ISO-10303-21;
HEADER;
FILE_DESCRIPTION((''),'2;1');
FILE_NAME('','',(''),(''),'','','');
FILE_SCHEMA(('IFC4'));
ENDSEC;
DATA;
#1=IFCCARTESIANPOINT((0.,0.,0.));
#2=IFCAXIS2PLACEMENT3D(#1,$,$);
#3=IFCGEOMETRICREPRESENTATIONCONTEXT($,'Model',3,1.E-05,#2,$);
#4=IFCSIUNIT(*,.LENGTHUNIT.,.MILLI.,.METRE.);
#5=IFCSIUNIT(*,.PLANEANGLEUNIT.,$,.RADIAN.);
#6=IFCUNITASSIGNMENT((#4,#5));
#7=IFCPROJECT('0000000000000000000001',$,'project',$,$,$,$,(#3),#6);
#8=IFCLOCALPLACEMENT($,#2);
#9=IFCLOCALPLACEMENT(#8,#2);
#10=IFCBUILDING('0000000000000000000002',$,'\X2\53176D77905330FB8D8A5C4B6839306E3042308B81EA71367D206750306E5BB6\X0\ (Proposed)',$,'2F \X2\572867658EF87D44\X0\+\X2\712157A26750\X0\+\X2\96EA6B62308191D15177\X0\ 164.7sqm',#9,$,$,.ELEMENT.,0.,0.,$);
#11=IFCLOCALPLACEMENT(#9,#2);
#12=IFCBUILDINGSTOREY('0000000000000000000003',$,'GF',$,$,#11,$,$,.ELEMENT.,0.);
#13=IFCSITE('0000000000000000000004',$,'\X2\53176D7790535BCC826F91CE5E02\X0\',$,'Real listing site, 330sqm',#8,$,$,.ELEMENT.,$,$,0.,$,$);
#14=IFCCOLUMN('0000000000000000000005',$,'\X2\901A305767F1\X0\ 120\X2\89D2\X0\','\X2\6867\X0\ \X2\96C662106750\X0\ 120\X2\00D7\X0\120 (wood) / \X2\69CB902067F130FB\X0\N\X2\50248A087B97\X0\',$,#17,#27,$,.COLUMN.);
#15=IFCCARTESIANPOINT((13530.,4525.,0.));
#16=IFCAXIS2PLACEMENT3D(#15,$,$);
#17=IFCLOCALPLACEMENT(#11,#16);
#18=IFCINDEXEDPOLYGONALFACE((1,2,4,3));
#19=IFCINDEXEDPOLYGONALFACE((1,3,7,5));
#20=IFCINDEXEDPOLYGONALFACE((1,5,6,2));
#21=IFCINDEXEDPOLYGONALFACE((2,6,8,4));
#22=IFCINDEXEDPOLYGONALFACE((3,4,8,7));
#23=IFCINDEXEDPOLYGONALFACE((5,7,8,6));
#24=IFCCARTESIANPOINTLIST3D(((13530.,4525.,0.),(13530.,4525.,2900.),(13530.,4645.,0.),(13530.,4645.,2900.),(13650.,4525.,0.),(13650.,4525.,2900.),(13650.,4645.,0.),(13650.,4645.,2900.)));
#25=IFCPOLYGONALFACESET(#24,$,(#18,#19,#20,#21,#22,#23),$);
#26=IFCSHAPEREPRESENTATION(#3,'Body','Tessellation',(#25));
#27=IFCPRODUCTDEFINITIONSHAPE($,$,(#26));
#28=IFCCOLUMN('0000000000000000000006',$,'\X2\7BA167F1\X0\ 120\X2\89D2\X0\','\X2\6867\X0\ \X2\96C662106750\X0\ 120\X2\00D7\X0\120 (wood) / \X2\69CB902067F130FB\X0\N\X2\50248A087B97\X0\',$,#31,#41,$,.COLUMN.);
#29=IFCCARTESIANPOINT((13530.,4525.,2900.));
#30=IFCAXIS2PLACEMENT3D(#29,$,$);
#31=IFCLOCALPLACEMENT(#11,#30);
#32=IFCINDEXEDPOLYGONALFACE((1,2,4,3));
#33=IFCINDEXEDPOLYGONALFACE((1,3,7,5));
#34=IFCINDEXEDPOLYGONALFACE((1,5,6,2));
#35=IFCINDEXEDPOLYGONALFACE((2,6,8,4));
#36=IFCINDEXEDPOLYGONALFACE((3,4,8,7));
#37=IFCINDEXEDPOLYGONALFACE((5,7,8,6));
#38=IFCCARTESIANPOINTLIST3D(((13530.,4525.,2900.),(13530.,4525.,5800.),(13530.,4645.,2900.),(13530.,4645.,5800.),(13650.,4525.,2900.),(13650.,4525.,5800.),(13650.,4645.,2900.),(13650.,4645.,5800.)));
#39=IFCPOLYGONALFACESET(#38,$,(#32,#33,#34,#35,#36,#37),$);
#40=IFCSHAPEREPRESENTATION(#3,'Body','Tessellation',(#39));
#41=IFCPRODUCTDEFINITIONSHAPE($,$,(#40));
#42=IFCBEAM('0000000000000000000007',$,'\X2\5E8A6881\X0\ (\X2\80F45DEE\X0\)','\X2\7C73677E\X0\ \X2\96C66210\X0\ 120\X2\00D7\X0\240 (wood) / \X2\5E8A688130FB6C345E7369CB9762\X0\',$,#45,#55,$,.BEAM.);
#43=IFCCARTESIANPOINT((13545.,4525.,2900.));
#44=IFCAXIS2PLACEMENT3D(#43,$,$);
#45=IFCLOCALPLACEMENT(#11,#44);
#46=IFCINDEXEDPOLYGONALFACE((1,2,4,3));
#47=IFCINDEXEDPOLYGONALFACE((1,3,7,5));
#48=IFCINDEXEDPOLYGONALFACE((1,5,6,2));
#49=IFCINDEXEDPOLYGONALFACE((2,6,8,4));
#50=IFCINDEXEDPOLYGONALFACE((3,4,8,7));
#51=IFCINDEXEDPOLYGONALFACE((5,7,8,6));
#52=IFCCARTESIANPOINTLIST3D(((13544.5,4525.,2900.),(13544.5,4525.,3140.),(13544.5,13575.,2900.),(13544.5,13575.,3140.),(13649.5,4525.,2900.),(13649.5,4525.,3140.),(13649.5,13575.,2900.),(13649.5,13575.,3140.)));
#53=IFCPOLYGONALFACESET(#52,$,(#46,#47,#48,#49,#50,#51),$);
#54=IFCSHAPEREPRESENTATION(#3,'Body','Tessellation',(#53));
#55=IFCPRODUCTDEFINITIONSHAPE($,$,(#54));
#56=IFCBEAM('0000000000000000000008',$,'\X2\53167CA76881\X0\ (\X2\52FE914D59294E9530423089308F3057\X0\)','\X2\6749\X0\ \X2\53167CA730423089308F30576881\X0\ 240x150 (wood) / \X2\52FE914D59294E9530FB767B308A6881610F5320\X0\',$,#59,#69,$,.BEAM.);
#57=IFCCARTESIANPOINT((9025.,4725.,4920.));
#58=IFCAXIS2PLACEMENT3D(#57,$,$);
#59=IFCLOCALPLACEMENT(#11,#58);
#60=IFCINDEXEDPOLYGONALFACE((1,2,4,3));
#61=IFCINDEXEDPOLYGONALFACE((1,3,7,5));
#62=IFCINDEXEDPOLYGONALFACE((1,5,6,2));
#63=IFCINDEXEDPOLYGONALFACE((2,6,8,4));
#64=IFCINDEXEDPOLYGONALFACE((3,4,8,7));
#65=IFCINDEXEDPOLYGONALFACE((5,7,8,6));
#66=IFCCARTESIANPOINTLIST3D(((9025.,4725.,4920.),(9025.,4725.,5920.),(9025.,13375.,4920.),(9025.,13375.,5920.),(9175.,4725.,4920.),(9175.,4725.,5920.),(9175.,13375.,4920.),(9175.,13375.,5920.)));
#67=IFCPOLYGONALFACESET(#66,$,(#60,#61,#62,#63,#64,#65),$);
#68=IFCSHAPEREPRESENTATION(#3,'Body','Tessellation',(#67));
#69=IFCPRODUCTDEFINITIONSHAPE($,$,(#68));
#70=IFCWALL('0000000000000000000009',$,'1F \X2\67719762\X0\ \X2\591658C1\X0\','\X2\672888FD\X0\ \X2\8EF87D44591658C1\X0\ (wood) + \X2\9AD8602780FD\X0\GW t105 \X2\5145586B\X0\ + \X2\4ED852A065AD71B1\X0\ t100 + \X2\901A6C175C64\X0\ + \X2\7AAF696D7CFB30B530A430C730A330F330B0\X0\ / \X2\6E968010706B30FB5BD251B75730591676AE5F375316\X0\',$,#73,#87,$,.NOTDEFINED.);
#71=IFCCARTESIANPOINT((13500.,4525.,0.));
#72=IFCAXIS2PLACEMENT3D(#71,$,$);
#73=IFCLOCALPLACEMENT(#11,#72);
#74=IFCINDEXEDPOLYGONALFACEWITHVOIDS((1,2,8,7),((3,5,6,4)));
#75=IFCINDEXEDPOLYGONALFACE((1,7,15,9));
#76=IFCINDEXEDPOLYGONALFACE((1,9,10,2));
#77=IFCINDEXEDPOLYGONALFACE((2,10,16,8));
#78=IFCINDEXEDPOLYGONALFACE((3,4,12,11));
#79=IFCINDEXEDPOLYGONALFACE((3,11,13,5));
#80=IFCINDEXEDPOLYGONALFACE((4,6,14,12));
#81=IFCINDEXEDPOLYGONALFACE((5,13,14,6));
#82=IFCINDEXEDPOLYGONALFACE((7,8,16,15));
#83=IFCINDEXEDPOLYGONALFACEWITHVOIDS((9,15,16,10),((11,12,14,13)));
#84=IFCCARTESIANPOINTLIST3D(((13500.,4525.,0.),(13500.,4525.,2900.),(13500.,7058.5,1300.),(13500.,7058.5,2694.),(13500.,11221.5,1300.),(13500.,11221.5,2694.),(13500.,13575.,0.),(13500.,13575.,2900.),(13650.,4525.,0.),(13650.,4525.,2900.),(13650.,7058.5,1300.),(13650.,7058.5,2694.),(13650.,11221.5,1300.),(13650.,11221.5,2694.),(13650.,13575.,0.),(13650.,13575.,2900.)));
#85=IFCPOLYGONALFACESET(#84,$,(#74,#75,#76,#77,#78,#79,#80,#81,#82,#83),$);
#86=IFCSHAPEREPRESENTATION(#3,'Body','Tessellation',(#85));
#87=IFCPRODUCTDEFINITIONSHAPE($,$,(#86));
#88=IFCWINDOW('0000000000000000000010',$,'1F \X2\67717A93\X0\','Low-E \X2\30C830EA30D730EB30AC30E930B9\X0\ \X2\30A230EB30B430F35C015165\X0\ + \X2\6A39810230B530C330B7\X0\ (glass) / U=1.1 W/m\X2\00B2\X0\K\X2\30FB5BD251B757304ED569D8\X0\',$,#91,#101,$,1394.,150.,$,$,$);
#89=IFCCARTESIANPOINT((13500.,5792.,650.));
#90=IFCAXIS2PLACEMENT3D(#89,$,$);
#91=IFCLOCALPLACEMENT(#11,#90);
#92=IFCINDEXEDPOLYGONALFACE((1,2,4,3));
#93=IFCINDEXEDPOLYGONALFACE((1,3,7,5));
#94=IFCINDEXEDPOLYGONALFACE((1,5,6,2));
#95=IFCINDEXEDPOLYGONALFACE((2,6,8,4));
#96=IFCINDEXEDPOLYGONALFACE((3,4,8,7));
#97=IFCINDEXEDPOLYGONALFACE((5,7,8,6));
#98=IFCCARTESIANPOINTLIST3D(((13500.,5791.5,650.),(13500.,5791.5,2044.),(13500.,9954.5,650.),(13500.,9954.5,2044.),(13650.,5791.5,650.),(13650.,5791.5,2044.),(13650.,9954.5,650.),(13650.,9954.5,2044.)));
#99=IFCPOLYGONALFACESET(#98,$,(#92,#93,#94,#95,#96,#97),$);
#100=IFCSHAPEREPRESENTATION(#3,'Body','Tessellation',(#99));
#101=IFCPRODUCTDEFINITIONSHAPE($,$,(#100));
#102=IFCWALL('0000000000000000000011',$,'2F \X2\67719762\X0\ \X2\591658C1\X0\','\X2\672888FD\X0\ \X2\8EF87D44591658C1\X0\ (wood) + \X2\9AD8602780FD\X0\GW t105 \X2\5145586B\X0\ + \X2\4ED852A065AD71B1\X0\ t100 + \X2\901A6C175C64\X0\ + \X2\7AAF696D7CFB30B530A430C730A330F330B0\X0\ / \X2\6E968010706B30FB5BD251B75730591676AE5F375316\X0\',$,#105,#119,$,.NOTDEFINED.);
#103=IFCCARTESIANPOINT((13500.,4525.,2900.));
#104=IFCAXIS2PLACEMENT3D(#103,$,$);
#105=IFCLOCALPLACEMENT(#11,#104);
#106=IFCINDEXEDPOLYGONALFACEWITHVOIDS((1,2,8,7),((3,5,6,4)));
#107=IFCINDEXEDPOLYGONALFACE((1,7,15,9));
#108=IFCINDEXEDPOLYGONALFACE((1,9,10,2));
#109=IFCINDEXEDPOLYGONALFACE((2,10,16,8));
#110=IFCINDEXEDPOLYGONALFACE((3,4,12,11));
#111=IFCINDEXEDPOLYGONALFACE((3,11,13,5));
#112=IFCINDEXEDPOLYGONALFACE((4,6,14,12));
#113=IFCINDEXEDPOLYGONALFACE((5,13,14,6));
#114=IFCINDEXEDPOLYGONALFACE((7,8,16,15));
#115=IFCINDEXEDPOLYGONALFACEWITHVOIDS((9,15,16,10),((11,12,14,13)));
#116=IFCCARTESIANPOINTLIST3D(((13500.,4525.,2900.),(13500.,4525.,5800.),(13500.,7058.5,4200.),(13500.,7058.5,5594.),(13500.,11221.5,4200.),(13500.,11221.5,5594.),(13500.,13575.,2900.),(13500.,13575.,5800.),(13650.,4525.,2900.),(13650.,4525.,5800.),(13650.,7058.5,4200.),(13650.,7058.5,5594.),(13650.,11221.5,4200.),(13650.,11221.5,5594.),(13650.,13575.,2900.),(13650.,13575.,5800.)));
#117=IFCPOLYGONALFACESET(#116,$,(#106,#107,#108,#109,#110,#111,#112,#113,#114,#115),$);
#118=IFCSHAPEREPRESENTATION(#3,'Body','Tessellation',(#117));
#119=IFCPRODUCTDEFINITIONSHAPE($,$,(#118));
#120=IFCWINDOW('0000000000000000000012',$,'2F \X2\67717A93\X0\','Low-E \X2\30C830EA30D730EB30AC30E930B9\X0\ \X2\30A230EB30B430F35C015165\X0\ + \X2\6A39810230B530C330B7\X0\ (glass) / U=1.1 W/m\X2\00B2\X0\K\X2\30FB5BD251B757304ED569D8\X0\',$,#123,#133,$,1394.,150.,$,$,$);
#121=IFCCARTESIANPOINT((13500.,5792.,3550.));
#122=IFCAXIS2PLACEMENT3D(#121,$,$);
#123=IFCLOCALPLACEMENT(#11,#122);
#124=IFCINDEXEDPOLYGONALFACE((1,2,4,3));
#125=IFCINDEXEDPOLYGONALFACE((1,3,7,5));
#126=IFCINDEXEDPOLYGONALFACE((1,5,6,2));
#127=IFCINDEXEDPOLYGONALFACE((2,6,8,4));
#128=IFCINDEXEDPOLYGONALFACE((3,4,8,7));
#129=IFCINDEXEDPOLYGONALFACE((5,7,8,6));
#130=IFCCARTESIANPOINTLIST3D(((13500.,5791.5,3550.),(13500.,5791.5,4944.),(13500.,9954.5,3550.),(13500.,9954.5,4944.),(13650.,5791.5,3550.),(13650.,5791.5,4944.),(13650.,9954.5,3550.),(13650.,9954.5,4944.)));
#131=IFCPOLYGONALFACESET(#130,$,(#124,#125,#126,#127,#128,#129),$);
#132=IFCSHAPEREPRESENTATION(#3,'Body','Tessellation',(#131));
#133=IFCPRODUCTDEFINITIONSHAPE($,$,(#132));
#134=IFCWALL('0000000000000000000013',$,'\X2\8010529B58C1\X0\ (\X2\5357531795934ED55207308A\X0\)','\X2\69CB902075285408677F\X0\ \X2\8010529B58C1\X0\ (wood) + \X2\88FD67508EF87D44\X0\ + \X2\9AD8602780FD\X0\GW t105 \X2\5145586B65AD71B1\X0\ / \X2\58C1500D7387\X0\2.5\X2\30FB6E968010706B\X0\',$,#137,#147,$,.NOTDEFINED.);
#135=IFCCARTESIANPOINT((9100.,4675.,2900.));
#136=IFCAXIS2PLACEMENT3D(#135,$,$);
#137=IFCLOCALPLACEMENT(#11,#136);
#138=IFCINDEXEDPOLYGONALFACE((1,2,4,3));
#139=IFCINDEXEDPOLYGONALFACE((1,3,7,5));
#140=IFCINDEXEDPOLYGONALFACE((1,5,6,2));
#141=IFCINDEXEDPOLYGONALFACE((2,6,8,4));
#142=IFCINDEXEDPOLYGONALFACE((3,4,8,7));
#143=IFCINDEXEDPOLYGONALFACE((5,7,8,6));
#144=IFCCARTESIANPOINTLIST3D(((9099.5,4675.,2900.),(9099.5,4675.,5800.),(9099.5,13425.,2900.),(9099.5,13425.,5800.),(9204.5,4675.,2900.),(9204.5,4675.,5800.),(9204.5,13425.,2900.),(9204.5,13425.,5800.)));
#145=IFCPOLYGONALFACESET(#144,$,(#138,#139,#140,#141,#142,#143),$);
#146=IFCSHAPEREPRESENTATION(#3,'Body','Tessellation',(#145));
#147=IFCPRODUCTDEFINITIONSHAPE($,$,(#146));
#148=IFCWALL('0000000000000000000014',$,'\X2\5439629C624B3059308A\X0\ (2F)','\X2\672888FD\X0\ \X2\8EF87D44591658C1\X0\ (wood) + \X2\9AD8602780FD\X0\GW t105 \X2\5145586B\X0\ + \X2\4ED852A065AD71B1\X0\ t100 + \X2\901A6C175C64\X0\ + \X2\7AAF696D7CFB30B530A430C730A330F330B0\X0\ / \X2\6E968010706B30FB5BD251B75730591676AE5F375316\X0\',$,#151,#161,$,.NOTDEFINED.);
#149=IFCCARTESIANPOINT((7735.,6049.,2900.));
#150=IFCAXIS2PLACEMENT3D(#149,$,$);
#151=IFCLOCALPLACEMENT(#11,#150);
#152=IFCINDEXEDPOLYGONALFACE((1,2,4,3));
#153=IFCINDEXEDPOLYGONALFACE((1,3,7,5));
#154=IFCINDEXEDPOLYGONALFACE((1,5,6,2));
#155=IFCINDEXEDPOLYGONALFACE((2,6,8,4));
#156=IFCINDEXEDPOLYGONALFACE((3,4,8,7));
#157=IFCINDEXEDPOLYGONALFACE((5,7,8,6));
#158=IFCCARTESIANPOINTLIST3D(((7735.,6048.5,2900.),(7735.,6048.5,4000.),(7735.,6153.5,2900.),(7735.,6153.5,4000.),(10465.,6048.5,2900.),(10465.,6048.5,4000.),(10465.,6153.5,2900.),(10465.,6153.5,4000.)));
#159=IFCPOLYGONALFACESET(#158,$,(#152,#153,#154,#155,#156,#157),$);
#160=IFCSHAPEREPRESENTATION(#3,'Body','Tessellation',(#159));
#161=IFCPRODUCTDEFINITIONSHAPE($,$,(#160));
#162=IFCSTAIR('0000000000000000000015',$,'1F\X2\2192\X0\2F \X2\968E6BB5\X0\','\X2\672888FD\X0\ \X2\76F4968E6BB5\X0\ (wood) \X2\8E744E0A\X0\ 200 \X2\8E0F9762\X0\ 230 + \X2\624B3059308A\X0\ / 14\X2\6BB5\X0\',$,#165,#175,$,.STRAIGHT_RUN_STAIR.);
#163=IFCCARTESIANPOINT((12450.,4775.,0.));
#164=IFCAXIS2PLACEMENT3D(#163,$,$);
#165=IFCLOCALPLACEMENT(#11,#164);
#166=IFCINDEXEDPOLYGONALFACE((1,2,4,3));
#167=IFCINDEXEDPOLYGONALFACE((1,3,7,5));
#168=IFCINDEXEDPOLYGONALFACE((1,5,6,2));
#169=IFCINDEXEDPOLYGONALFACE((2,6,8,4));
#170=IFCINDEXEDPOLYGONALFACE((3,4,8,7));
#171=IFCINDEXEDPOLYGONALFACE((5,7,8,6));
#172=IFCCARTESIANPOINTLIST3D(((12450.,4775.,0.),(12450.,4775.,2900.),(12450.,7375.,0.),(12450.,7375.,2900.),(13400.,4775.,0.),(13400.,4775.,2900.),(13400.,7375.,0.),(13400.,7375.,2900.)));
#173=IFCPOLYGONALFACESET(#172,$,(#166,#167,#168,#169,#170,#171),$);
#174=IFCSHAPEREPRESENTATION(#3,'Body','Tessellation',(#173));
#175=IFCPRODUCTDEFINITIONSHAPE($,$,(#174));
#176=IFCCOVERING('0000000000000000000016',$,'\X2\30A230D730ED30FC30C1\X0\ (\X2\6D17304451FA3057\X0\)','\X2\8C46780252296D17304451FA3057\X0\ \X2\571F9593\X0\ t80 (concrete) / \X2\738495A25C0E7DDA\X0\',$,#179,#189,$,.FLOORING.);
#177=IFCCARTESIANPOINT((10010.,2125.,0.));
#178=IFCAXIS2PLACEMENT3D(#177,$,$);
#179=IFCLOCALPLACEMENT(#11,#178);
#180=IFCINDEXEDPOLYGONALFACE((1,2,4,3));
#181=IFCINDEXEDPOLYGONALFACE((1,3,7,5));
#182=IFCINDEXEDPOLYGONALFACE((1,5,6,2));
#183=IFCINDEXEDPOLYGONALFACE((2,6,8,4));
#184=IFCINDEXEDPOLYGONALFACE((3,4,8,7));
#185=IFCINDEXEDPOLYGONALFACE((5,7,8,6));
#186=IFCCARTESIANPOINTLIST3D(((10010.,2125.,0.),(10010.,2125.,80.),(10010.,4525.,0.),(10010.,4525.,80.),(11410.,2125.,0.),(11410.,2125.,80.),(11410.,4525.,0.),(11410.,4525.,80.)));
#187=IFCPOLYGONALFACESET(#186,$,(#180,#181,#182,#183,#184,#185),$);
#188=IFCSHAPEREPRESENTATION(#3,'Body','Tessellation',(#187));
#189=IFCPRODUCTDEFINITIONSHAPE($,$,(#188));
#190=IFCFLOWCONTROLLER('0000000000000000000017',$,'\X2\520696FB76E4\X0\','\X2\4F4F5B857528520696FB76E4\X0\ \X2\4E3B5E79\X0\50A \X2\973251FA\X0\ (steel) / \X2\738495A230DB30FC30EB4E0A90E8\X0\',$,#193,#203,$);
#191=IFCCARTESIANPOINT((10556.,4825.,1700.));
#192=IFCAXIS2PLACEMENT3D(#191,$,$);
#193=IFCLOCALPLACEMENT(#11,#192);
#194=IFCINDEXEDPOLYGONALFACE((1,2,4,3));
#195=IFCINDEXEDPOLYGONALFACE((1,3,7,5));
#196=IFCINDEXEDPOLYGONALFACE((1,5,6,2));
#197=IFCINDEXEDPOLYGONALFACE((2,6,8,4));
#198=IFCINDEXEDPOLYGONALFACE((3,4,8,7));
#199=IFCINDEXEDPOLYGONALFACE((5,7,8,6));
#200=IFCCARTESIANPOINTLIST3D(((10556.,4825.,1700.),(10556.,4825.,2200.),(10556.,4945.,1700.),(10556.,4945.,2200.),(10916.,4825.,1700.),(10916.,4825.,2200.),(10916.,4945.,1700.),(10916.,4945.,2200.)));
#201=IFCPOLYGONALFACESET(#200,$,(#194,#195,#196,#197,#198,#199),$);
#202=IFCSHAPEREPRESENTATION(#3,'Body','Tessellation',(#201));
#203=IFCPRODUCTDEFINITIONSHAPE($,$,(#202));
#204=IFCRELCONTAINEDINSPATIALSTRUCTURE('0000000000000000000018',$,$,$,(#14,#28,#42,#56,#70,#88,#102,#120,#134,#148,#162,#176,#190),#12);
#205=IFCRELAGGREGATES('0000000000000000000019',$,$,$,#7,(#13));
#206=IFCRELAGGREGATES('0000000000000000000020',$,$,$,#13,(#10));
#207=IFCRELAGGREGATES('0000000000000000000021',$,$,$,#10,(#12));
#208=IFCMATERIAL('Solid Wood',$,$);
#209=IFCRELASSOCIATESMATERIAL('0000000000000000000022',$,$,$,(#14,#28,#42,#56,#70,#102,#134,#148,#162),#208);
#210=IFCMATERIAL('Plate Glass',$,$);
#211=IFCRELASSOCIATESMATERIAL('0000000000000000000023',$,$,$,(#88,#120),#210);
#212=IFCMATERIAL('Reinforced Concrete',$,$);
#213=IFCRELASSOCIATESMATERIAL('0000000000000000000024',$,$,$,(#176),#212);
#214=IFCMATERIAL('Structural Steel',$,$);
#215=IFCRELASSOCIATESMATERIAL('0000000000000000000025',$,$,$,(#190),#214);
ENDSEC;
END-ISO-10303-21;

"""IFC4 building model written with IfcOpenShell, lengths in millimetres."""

from ifc_helpers import new_model, si_unit, frame, frame_2d, origin, place, context, project, spatial, rectangle, extrude, material, element, fill, save


model = new_model("IFC4")

# Units and contexts
model_context = context("Model", 3, precision=1e-05, world=origin())
ifc_project = project(units=[si_unit("LENGTHUNIT", "METRE", prefix="MILLI"), si_unit("PLANEANGLEUNIT", "RADIAN")], contexts=[model_context])

# Site, building, storey
site_placement = place(None, origin())
site = spatial("IfcSite", under=ifc_project, at=site_placement, Name="北海道富良野市", ObjectType="Real listing site, 330sqm", CompositionType="ELEMENT", RefElevation=0.0)
building_placement = place(site_placement, origin())
building = spatial("IfcBuilding", under=site, at=building_placement, Name="北海道・越屋根のある自然素材の家 (Proposed)", ObjectType="2F 在来軸組+無垢材+雪止め金具 164.7sqm", CompositionType="ELEMENT", ElevationOfRefHeight=0.0, ElevationOfTerrain=0.0)
storey_placement = place(building_placement, origin())
storey = spatial("IfcBuildingStorey", under=building, at=storey_placement, Name="GF", CompositionType="ELEMENT", Elevation=0.0)

# Columns
ifc_material_1 = material(Name="Solid Wood")
column_1_placement = place(storey_placement, frame((13530.0, 4525.0, 0.0)))
element("IfcColumn", 1, at=column_1_placement, inside=storey, material=ifc_material_1, Name="通し柱 120角", Description="桧 集成材 120×120 (wood) / 構造柱・N値計算", PredefinedType="COLUMN", context=model_context, shape_type="SweptSolid", body=[
    extrude(rectangle(XDim=120.0, YDim=120.0, at=frame_2d((60.0, 60.0))), frame((13530.0, 4525.0, 0.0)), (0.0, 0.0, 1.0), 2900.0),
])
column_2_placement = place(storey_placement, frame((13530.0, 4525.0, 2900.0)))
element("IfcColumn", 2, at=column_2_placement, inside=storey, material=ifc_material_1, Name="管柱 120角", Description="桧 集成材 120×120 (wood) / 構造柱・N値計算", PredefinedType="COLUMN", context=model_context, shape_type="SweptSolid", body=[
    extrude(rectangle(XDim=120.0, YDim=120.0, at=frame_2d((60.0, 60.0))), frame((13530.0, 4525.0, 2900.0)), (0.0, 0.0, 1.0), 2900.0),
])

# Beams
beam_1_placement = place(storey_placement, frame((13545.0, 4525.0, 2900.0)))
element("IfcBeam", 3, at=beam_1_placement, inside=storey, material=ifc_material_1, Name="床梁 (胴差)", Description="米松 集成 120×240 (wood) / 床梁・水平構面", PredefinedType="BEAM", context=model_context, shape_type="SweptSolid", body=[
    extrude(rectangle(XDim=105.0, YDim=9050.0, at=frame_2d((52.0, 4525.0))), frame((13545.0, 4525.0, 2900.0)), (0.0, 0.0, 1.0), 240.0),
])
beam_2_placement = place(storey_placement, frame((9025.0, 4725.0, 4920.0)))
element("IfcBeam", 4, at=beam_2_placement, inside=storey, material=ifc_material_1, Name="化粧梁 (勾配天井あらわし)", Description="杉 化粧あらわし梁 240x150 (wood) / 勾配天井・登り梁意匠", PredefinedType="BEAM", context=model_context, shape_type="SweptSolid", body=[
    extrude(rectangle(XDim=150.0, YDim=8650.0, at=frame_2d((75.0, 4325.0))), frame((9025.0, 4725.0, 4920.0)), (0.0, 0.0, 1.0), 1000.0),
])

# Wall, opening, window
wall_1_placement = place(storey_placement, frame((13500.0, 4525.0, 0.0)))
wall_1 = element("IfcWall", 5, at=wall_1_placement, inside=storey, material=ifc_material_1, Name="1F 東面 外壁", Description="木製 軸組外壁 (wood) + 高性能GW t105 充填 + 付加断熱 t100 + 通気層 + 窯業系サイディング / 準耐火・寒冷地外皮強化", PredefinedType="NOTDEFINED", context=model_context, shape_type="SweptSolid", body=[
    extrude(rectangle(XDim=150.0, YDim=9050.0, at=frame_2d((75.0, 4525.0))), frame((13500.0, 4525.0, 0.0)), (0.0, 0.0, 1.0), 2900.0),
])
opening_1_placement = place(storey_placement, frame((13500.0, 5792.0, 650.0)))
opening_1 = element("IfcOpeningElement", 6, at=opening_1_placement, cuts=wall_1, PredefinedType="NOTDEFINED", context=model_context, shape_type="SweptSolid", body=[
    extrude(rectangle(XDim=150.0, YDim=4163.0, at=frame_2d((75.0, 2081.0))), frame((13500.0, 5792.0, 650.0)), (0.0, 0.0, 1.0), 1394.0),
])
ifc_material_2 = material(Name="Plate Glass")
window_1_placement = place(storey_placement, frame((13500.0, 5792.0, 650.0)))
window_1 = element("IfcWindow", 7, at=window_1_placement, inside=storey, material=ifc_material_2, Name="1F 東窓", Description="Low-E トリプルガラス アルゴン封入 + 樹脂サッシ (glass) / U=1.1 W/m²K・寒冷地仕様", OverallHeight=1394.0, OverallWidth=150.0, context=model_context, shape_type="SweptSolid", body=[
    extrude(rectangle(XDim=150.0, YDim=4163.0, at=frame_2d((75.0, 2081.0))), frame((13500.0, 5792.0, 650.0)), (0.0, 0.0, 1.0), 1394.0),
])
fill(opening_1, window_1)

# Wall, opening, window
wall_2_placement = place(storey_placement, frame((13500.0, 4525.0, 2900.0)))
wall_2 = element("IfcWall", 8, at=wall_2_placement, inside=storey, material=ifc_material_1, Name="2F 東面 外壁", Description="木製 軸組外壁 (wood) + 高性能GW t105 充填 + 付加断熱 t100 + 通気層 + 窯業系サイディング / 準耐火・寒冷地外皮強化", PredefinedType="NOTDEFINED", context=model_context, shape_type="SweptSolid", body=[
    extrude(rectangle(XDim=150.0, YDim=9050.0, at=frame_2d((75.0, 4525.0))), frame((13500.0, 4525.0, 2900.0)), (0.0, 0.0, 1.0), 2900.0),
])
opening_2_placement = place(storey_placement, frame((13500.0, 5792.0, 3550.0)))
opening_2 = element("IfcOpeningElement", 9, at=opening_2_placement, cuts=wall_2, PredefinedType="NOTDEFINED", context=model_context, shape_type="SweptSolid", body=[
    extrude(rectangle(XDim=150.0, YDim=4163.0, at=frame_2d((75.0, 2081.0))), frame((13500.0, 5792.0, 3550.0)), (0.0, 0.0, 1.0), 1394.0),
])
window_2_placement = place(storey_placement, frame((13500.0, 5792.0, 3550.0)))
window_2 = element("IfcWindow", 10, at=window_2_placement, inside=storey, material=ifc_material_2, Name="2F 東窓", Description="Low-E トリプルガラス アルゴン封入 + 樹脂サッシ (glass) / U=1.1 W/m²K・寒冷地仕様", OverallHeight=1394.0, OverallWidth=150.0, context=model_context, shape_type="SweptSolid", body=[
    extrude(rectangle(XDim=150.0, YDim=4163.0, at=frame_2d((75.0, 2081.0))), frame((13500.0, 5792.0, 3550.0)), (0.0, 0.0, 1.0), 1394.0),
])
fill(opening_2, window_2)

# Walls
wall_3_placement = place(storey_placement, frame((9100.0, 4675.0, 2900.0)))
element("IfcWall", 11, at=wall_3_placement, inside=storey, material=ifc_material_1, Name="耐力壁 (南北間仕切り)", Description="構造用合板 耐力壁 (wood) + 製材軸組 + 高性能GW t105 充填断熱 / 壁倍率2.5・準耐火", PredefinedType="NOTDEFINED", context=model_context, shape_type="SweptSolid", body=[
    extrude(rectangle(XDim=105.0, YDim=8750.0, at=frame_2d((52.0, 4375.0))), frame((9100.0, 4675.0, 2900.0)), (0.0, 0.0, 1.0), 2900.0),
])
wall_4_placement = place(storey_placement, frame((7735.0, 6049.0, 2900.0)))
element("IfcWall", 12, at=wall_4_placement, inside=storey, material=ifc_material_1, Name="吹抜手すり (2F)", Description="木製 軸組外壁 (wood) + 高性能GW t105 充填 + 付加断熱 t100 + 通気層 + 窯業系サイディング / 準耐火・寒冷地外皮強化", PredefinedType="NOTDEFINED", context=model_context, shape_type="SweptSolid", body=[
    extrude(rectangle(XDim=2730.0, YDim=105.0, at=frame_2d((1365.0, 52.0))), frame((7735.0, 6049.0, 2900.0)), (0.0, 0.0, 1.0), 1100.0),
])

# Stair
stair_placement = place(storey_placement, frame((12450.0, 4775.0, 0.0)))
element("IfcStair", 13, at=stair_placement, inside=storey, material=ifc_material_1, Name="1F→2F 階段", Description="木製 直階段 (wood) 蹴上 200 踏面 230 + 手すり / 14段", PredefinedType="STRAIGHT_RUN_STAIR", context=model_context, shape_type="SweptSolid", body=[
    extrude(rectangle(XDim=950.0, YDim=2600.0, at=frame_2d((475.0, 1300.0))), frame((12450.0, 4775.0, 0.0)), (0.0, 0.0, 1.0), 2900.0),
])

# Covering
ifc_material_3 = material(Name="Reinforced Concrete")
covering_placement = place(storey_placement, frame((10010.0, 2125.0, 0.0)))
element("IfcCovering", 14, at=covering_placement, inside=storey, material=ifc_material_3, Name="アプローチ (洗い出し)", Description="豆砂利洗い出し 土間 t80 (concrete) / 玄関導線", PredefinedType="FLOORING", context=model_context, shape_type="SweptSolid", body=[
    extrude(rectangle(XDim=1400.0, YDim=2400.0, at=frame_2d((700.0, 1200.0))), frame((10010.0, 2125.0, 0.0)), (0.0, 0.0, 1.0), 80.0),
])

# Flow controller
ifc_material_4 = material(Name="Structural Steel")
flow_controller_placement = place(storey_placement, frame((10556.0, 4825.0, 1700.0)))
element("IfcFlowController", 15, at=flow_controller_placement, inside=storey, material=ifc_material_4, Name="分電盤", Description="住宅用分電盤 主幹50A 露出 (steel) / 玄関ホール上部", context=model_context, shape_type="SweptSolid", body=[
    extrude(rectangle(XDim=360.0, YDim=120.0, at=frame_2d((180.0, 60.0))), frame((10556.0, 4825.0, 1700.0)), (0.0, 0.0, 1.0), 500.0),
])

save(model, "model.ifc")
